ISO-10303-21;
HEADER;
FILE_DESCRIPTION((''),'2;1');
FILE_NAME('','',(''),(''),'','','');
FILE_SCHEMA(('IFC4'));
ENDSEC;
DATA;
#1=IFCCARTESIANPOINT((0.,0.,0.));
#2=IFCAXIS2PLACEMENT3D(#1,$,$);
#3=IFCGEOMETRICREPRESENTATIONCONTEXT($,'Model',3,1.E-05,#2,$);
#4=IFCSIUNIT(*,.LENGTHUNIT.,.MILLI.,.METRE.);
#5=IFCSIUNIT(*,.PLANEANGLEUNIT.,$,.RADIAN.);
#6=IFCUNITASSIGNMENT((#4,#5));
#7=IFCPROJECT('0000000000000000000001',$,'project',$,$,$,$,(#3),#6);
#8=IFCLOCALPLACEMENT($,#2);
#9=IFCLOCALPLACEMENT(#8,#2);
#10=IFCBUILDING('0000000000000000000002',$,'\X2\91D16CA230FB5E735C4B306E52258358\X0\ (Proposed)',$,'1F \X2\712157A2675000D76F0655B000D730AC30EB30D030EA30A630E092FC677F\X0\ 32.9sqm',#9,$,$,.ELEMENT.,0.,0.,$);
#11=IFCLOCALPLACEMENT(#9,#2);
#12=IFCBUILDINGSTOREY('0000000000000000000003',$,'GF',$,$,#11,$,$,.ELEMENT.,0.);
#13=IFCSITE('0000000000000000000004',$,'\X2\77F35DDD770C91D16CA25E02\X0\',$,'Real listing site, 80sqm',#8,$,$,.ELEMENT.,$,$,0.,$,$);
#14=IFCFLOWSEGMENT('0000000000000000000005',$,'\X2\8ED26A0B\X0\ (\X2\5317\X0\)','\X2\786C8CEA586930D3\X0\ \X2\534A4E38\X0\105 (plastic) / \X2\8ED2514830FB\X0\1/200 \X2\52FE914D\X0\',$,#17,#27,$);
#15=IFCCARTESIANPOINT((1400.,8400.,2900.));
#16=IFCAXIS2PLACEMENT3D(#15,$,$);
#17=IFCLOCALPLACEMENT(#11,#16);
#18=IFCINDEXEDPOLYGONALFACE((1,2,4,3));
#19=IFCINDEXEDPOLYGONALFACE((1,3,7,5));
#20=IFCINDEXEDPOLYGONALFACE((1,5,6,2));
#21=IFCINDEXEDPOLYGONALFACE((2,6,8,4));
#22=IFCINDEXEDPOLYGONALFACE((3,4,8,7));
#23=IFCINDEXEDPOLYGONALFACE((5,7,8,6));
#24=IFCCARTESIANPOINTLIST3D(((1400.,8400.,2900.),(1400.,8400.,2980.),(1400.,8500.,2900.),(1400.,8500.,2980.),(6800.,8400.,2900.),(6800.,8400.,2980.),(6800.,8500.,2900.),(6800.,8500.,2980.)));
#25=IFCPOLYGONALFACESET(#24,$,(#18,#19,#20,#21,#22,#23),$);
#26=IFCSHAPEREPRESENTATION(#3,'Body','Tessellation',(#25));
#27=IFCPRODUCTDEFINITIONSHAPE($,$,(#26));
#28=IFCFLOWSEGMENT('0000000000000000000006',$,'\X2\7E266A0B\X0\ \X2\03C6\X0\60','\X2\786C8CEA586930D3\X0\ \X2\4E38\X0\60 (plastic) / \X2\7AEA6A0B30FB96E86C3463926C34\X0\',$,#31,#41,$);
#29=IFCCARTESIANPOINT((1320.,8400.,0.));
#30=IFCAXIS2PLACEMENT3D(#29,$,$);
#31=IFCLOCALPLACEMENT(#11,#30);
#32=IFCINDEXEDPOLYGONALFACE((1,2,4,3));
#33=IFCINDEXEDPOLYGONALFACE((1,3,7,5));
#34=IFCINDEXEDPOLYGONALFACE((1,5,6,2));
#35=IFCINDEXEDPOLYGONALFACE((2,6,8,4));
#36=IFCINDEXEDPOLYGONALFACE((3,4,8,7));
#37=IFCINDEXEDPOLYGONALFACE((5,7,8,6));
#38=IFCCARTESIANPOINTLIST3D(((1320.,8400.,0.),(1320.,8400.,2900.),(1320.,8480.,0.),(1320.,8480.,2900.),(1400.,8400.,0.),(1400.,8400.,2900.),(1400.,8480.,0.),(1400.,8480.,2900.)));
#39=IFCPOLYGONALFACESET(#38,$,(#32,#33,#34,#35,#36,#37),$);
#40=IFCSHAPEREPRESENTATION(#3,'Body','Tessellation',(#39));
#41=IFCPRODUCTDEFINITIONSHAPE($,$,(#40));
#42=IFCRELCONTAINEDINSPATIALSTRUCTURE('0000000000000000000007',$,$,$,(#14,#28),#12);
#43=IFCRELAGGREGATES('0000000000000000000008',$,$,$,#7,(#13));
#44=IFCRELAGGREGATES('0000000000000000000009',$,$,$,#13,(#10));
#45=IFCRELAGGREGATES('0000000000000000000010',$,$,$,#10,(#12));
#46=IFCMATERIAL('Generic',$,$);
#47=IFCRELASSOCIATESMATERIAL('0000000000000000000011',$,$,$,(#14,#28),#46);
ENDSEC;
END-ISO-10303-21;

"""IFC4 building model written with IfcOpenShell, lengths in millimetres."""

from ifc_helpers import new_model, si_unit, frame, frame_2d, origin, place, context, project, spatial, rectangle, extrude, material, element, save


model = new_model("IFC4")

# Units and contexts
model_context = context("Model", 3, precision=1e-05, world=origin())
ifc_project = project(units=[si_unit("LENGTHUNIT", "METRE", prefix="MILLI"), si_unit("PLANEANGLEUNIT", "RADIAN")], contexts=[model_context])

# Site, building, storey
site_placement = place(None, origin())
site = spatial("IfcSite", under=ifc_project, at=site_placement, Name="石川県金沢市", ObjectType="Real listing site, 80sqm", CompositionType="ELEMENT", RefElevation=0.0)
building_placement = place(site_placement, origin())
building = spatial("IfcBuilding", under=site, at=building_placement, Name="金沢・平屋の別荘 (Proposed)", ObjectType="1F 無垢材×漆喰×ガルバリウム鋼板 32.9sqm", CompositionType="ELEMENT", ElevationOfRefHeight=0.0, ElevationOfTerrain=0.0)
storey_placement = place(building_placement, origin())
storey = spatial("IfcBuildingStorey", under=building, at=storey_placement, Name="GF", CompositionType="ELEMENT", Elevation=0.0)

# Shared definitions
ifc_material_1 = material(Name="Generic")

# Flow segments
flow_segment_1_placement = place(storey_placement, frame((1400.0, 8400.0, 2900.0)))
element("IfcFlowSegment", 1, at=flow_segment_1_placement, inside=storey, material=ifc_material_1, Name="軒樋 (北)", Description="硬質塩ビ 半丸105 (plastic) / 軒先・1/200 勾配", context=model_context, shape_type="SweptSolid", body=[
    extrude(rectangle(XDim=5400.0, YDim=100.0, at=frame_2d((2700.0, 50.0))), frame((1400.0, 8400.0, 2900.0)), (0.0, 0.0, 1.0), 80.0),
])
flow_segment_2_placement = place(storey_placement, frame((1320.0, 8400.0, 0.0)))
element("IfcFlowSegment", 2, at=flow_segment_2_placement, inside=storey, material=ifc_material_1, Name="縦樋 φ60", Description="硬質塩ビ 丸60 (plastic) / 竪樋・雨水排水", context=model_context, shape_type="SweptSolid", body=[
    extrude(rectangle(XDim=80.0, YDim=80.0, at=frame_2d((40.0, 40.0))), frame((1320.0, 8400.0, 0.0)), (0.0, 0.0, 1.0), 2900.0),
])

save(model, "model.ifc")
